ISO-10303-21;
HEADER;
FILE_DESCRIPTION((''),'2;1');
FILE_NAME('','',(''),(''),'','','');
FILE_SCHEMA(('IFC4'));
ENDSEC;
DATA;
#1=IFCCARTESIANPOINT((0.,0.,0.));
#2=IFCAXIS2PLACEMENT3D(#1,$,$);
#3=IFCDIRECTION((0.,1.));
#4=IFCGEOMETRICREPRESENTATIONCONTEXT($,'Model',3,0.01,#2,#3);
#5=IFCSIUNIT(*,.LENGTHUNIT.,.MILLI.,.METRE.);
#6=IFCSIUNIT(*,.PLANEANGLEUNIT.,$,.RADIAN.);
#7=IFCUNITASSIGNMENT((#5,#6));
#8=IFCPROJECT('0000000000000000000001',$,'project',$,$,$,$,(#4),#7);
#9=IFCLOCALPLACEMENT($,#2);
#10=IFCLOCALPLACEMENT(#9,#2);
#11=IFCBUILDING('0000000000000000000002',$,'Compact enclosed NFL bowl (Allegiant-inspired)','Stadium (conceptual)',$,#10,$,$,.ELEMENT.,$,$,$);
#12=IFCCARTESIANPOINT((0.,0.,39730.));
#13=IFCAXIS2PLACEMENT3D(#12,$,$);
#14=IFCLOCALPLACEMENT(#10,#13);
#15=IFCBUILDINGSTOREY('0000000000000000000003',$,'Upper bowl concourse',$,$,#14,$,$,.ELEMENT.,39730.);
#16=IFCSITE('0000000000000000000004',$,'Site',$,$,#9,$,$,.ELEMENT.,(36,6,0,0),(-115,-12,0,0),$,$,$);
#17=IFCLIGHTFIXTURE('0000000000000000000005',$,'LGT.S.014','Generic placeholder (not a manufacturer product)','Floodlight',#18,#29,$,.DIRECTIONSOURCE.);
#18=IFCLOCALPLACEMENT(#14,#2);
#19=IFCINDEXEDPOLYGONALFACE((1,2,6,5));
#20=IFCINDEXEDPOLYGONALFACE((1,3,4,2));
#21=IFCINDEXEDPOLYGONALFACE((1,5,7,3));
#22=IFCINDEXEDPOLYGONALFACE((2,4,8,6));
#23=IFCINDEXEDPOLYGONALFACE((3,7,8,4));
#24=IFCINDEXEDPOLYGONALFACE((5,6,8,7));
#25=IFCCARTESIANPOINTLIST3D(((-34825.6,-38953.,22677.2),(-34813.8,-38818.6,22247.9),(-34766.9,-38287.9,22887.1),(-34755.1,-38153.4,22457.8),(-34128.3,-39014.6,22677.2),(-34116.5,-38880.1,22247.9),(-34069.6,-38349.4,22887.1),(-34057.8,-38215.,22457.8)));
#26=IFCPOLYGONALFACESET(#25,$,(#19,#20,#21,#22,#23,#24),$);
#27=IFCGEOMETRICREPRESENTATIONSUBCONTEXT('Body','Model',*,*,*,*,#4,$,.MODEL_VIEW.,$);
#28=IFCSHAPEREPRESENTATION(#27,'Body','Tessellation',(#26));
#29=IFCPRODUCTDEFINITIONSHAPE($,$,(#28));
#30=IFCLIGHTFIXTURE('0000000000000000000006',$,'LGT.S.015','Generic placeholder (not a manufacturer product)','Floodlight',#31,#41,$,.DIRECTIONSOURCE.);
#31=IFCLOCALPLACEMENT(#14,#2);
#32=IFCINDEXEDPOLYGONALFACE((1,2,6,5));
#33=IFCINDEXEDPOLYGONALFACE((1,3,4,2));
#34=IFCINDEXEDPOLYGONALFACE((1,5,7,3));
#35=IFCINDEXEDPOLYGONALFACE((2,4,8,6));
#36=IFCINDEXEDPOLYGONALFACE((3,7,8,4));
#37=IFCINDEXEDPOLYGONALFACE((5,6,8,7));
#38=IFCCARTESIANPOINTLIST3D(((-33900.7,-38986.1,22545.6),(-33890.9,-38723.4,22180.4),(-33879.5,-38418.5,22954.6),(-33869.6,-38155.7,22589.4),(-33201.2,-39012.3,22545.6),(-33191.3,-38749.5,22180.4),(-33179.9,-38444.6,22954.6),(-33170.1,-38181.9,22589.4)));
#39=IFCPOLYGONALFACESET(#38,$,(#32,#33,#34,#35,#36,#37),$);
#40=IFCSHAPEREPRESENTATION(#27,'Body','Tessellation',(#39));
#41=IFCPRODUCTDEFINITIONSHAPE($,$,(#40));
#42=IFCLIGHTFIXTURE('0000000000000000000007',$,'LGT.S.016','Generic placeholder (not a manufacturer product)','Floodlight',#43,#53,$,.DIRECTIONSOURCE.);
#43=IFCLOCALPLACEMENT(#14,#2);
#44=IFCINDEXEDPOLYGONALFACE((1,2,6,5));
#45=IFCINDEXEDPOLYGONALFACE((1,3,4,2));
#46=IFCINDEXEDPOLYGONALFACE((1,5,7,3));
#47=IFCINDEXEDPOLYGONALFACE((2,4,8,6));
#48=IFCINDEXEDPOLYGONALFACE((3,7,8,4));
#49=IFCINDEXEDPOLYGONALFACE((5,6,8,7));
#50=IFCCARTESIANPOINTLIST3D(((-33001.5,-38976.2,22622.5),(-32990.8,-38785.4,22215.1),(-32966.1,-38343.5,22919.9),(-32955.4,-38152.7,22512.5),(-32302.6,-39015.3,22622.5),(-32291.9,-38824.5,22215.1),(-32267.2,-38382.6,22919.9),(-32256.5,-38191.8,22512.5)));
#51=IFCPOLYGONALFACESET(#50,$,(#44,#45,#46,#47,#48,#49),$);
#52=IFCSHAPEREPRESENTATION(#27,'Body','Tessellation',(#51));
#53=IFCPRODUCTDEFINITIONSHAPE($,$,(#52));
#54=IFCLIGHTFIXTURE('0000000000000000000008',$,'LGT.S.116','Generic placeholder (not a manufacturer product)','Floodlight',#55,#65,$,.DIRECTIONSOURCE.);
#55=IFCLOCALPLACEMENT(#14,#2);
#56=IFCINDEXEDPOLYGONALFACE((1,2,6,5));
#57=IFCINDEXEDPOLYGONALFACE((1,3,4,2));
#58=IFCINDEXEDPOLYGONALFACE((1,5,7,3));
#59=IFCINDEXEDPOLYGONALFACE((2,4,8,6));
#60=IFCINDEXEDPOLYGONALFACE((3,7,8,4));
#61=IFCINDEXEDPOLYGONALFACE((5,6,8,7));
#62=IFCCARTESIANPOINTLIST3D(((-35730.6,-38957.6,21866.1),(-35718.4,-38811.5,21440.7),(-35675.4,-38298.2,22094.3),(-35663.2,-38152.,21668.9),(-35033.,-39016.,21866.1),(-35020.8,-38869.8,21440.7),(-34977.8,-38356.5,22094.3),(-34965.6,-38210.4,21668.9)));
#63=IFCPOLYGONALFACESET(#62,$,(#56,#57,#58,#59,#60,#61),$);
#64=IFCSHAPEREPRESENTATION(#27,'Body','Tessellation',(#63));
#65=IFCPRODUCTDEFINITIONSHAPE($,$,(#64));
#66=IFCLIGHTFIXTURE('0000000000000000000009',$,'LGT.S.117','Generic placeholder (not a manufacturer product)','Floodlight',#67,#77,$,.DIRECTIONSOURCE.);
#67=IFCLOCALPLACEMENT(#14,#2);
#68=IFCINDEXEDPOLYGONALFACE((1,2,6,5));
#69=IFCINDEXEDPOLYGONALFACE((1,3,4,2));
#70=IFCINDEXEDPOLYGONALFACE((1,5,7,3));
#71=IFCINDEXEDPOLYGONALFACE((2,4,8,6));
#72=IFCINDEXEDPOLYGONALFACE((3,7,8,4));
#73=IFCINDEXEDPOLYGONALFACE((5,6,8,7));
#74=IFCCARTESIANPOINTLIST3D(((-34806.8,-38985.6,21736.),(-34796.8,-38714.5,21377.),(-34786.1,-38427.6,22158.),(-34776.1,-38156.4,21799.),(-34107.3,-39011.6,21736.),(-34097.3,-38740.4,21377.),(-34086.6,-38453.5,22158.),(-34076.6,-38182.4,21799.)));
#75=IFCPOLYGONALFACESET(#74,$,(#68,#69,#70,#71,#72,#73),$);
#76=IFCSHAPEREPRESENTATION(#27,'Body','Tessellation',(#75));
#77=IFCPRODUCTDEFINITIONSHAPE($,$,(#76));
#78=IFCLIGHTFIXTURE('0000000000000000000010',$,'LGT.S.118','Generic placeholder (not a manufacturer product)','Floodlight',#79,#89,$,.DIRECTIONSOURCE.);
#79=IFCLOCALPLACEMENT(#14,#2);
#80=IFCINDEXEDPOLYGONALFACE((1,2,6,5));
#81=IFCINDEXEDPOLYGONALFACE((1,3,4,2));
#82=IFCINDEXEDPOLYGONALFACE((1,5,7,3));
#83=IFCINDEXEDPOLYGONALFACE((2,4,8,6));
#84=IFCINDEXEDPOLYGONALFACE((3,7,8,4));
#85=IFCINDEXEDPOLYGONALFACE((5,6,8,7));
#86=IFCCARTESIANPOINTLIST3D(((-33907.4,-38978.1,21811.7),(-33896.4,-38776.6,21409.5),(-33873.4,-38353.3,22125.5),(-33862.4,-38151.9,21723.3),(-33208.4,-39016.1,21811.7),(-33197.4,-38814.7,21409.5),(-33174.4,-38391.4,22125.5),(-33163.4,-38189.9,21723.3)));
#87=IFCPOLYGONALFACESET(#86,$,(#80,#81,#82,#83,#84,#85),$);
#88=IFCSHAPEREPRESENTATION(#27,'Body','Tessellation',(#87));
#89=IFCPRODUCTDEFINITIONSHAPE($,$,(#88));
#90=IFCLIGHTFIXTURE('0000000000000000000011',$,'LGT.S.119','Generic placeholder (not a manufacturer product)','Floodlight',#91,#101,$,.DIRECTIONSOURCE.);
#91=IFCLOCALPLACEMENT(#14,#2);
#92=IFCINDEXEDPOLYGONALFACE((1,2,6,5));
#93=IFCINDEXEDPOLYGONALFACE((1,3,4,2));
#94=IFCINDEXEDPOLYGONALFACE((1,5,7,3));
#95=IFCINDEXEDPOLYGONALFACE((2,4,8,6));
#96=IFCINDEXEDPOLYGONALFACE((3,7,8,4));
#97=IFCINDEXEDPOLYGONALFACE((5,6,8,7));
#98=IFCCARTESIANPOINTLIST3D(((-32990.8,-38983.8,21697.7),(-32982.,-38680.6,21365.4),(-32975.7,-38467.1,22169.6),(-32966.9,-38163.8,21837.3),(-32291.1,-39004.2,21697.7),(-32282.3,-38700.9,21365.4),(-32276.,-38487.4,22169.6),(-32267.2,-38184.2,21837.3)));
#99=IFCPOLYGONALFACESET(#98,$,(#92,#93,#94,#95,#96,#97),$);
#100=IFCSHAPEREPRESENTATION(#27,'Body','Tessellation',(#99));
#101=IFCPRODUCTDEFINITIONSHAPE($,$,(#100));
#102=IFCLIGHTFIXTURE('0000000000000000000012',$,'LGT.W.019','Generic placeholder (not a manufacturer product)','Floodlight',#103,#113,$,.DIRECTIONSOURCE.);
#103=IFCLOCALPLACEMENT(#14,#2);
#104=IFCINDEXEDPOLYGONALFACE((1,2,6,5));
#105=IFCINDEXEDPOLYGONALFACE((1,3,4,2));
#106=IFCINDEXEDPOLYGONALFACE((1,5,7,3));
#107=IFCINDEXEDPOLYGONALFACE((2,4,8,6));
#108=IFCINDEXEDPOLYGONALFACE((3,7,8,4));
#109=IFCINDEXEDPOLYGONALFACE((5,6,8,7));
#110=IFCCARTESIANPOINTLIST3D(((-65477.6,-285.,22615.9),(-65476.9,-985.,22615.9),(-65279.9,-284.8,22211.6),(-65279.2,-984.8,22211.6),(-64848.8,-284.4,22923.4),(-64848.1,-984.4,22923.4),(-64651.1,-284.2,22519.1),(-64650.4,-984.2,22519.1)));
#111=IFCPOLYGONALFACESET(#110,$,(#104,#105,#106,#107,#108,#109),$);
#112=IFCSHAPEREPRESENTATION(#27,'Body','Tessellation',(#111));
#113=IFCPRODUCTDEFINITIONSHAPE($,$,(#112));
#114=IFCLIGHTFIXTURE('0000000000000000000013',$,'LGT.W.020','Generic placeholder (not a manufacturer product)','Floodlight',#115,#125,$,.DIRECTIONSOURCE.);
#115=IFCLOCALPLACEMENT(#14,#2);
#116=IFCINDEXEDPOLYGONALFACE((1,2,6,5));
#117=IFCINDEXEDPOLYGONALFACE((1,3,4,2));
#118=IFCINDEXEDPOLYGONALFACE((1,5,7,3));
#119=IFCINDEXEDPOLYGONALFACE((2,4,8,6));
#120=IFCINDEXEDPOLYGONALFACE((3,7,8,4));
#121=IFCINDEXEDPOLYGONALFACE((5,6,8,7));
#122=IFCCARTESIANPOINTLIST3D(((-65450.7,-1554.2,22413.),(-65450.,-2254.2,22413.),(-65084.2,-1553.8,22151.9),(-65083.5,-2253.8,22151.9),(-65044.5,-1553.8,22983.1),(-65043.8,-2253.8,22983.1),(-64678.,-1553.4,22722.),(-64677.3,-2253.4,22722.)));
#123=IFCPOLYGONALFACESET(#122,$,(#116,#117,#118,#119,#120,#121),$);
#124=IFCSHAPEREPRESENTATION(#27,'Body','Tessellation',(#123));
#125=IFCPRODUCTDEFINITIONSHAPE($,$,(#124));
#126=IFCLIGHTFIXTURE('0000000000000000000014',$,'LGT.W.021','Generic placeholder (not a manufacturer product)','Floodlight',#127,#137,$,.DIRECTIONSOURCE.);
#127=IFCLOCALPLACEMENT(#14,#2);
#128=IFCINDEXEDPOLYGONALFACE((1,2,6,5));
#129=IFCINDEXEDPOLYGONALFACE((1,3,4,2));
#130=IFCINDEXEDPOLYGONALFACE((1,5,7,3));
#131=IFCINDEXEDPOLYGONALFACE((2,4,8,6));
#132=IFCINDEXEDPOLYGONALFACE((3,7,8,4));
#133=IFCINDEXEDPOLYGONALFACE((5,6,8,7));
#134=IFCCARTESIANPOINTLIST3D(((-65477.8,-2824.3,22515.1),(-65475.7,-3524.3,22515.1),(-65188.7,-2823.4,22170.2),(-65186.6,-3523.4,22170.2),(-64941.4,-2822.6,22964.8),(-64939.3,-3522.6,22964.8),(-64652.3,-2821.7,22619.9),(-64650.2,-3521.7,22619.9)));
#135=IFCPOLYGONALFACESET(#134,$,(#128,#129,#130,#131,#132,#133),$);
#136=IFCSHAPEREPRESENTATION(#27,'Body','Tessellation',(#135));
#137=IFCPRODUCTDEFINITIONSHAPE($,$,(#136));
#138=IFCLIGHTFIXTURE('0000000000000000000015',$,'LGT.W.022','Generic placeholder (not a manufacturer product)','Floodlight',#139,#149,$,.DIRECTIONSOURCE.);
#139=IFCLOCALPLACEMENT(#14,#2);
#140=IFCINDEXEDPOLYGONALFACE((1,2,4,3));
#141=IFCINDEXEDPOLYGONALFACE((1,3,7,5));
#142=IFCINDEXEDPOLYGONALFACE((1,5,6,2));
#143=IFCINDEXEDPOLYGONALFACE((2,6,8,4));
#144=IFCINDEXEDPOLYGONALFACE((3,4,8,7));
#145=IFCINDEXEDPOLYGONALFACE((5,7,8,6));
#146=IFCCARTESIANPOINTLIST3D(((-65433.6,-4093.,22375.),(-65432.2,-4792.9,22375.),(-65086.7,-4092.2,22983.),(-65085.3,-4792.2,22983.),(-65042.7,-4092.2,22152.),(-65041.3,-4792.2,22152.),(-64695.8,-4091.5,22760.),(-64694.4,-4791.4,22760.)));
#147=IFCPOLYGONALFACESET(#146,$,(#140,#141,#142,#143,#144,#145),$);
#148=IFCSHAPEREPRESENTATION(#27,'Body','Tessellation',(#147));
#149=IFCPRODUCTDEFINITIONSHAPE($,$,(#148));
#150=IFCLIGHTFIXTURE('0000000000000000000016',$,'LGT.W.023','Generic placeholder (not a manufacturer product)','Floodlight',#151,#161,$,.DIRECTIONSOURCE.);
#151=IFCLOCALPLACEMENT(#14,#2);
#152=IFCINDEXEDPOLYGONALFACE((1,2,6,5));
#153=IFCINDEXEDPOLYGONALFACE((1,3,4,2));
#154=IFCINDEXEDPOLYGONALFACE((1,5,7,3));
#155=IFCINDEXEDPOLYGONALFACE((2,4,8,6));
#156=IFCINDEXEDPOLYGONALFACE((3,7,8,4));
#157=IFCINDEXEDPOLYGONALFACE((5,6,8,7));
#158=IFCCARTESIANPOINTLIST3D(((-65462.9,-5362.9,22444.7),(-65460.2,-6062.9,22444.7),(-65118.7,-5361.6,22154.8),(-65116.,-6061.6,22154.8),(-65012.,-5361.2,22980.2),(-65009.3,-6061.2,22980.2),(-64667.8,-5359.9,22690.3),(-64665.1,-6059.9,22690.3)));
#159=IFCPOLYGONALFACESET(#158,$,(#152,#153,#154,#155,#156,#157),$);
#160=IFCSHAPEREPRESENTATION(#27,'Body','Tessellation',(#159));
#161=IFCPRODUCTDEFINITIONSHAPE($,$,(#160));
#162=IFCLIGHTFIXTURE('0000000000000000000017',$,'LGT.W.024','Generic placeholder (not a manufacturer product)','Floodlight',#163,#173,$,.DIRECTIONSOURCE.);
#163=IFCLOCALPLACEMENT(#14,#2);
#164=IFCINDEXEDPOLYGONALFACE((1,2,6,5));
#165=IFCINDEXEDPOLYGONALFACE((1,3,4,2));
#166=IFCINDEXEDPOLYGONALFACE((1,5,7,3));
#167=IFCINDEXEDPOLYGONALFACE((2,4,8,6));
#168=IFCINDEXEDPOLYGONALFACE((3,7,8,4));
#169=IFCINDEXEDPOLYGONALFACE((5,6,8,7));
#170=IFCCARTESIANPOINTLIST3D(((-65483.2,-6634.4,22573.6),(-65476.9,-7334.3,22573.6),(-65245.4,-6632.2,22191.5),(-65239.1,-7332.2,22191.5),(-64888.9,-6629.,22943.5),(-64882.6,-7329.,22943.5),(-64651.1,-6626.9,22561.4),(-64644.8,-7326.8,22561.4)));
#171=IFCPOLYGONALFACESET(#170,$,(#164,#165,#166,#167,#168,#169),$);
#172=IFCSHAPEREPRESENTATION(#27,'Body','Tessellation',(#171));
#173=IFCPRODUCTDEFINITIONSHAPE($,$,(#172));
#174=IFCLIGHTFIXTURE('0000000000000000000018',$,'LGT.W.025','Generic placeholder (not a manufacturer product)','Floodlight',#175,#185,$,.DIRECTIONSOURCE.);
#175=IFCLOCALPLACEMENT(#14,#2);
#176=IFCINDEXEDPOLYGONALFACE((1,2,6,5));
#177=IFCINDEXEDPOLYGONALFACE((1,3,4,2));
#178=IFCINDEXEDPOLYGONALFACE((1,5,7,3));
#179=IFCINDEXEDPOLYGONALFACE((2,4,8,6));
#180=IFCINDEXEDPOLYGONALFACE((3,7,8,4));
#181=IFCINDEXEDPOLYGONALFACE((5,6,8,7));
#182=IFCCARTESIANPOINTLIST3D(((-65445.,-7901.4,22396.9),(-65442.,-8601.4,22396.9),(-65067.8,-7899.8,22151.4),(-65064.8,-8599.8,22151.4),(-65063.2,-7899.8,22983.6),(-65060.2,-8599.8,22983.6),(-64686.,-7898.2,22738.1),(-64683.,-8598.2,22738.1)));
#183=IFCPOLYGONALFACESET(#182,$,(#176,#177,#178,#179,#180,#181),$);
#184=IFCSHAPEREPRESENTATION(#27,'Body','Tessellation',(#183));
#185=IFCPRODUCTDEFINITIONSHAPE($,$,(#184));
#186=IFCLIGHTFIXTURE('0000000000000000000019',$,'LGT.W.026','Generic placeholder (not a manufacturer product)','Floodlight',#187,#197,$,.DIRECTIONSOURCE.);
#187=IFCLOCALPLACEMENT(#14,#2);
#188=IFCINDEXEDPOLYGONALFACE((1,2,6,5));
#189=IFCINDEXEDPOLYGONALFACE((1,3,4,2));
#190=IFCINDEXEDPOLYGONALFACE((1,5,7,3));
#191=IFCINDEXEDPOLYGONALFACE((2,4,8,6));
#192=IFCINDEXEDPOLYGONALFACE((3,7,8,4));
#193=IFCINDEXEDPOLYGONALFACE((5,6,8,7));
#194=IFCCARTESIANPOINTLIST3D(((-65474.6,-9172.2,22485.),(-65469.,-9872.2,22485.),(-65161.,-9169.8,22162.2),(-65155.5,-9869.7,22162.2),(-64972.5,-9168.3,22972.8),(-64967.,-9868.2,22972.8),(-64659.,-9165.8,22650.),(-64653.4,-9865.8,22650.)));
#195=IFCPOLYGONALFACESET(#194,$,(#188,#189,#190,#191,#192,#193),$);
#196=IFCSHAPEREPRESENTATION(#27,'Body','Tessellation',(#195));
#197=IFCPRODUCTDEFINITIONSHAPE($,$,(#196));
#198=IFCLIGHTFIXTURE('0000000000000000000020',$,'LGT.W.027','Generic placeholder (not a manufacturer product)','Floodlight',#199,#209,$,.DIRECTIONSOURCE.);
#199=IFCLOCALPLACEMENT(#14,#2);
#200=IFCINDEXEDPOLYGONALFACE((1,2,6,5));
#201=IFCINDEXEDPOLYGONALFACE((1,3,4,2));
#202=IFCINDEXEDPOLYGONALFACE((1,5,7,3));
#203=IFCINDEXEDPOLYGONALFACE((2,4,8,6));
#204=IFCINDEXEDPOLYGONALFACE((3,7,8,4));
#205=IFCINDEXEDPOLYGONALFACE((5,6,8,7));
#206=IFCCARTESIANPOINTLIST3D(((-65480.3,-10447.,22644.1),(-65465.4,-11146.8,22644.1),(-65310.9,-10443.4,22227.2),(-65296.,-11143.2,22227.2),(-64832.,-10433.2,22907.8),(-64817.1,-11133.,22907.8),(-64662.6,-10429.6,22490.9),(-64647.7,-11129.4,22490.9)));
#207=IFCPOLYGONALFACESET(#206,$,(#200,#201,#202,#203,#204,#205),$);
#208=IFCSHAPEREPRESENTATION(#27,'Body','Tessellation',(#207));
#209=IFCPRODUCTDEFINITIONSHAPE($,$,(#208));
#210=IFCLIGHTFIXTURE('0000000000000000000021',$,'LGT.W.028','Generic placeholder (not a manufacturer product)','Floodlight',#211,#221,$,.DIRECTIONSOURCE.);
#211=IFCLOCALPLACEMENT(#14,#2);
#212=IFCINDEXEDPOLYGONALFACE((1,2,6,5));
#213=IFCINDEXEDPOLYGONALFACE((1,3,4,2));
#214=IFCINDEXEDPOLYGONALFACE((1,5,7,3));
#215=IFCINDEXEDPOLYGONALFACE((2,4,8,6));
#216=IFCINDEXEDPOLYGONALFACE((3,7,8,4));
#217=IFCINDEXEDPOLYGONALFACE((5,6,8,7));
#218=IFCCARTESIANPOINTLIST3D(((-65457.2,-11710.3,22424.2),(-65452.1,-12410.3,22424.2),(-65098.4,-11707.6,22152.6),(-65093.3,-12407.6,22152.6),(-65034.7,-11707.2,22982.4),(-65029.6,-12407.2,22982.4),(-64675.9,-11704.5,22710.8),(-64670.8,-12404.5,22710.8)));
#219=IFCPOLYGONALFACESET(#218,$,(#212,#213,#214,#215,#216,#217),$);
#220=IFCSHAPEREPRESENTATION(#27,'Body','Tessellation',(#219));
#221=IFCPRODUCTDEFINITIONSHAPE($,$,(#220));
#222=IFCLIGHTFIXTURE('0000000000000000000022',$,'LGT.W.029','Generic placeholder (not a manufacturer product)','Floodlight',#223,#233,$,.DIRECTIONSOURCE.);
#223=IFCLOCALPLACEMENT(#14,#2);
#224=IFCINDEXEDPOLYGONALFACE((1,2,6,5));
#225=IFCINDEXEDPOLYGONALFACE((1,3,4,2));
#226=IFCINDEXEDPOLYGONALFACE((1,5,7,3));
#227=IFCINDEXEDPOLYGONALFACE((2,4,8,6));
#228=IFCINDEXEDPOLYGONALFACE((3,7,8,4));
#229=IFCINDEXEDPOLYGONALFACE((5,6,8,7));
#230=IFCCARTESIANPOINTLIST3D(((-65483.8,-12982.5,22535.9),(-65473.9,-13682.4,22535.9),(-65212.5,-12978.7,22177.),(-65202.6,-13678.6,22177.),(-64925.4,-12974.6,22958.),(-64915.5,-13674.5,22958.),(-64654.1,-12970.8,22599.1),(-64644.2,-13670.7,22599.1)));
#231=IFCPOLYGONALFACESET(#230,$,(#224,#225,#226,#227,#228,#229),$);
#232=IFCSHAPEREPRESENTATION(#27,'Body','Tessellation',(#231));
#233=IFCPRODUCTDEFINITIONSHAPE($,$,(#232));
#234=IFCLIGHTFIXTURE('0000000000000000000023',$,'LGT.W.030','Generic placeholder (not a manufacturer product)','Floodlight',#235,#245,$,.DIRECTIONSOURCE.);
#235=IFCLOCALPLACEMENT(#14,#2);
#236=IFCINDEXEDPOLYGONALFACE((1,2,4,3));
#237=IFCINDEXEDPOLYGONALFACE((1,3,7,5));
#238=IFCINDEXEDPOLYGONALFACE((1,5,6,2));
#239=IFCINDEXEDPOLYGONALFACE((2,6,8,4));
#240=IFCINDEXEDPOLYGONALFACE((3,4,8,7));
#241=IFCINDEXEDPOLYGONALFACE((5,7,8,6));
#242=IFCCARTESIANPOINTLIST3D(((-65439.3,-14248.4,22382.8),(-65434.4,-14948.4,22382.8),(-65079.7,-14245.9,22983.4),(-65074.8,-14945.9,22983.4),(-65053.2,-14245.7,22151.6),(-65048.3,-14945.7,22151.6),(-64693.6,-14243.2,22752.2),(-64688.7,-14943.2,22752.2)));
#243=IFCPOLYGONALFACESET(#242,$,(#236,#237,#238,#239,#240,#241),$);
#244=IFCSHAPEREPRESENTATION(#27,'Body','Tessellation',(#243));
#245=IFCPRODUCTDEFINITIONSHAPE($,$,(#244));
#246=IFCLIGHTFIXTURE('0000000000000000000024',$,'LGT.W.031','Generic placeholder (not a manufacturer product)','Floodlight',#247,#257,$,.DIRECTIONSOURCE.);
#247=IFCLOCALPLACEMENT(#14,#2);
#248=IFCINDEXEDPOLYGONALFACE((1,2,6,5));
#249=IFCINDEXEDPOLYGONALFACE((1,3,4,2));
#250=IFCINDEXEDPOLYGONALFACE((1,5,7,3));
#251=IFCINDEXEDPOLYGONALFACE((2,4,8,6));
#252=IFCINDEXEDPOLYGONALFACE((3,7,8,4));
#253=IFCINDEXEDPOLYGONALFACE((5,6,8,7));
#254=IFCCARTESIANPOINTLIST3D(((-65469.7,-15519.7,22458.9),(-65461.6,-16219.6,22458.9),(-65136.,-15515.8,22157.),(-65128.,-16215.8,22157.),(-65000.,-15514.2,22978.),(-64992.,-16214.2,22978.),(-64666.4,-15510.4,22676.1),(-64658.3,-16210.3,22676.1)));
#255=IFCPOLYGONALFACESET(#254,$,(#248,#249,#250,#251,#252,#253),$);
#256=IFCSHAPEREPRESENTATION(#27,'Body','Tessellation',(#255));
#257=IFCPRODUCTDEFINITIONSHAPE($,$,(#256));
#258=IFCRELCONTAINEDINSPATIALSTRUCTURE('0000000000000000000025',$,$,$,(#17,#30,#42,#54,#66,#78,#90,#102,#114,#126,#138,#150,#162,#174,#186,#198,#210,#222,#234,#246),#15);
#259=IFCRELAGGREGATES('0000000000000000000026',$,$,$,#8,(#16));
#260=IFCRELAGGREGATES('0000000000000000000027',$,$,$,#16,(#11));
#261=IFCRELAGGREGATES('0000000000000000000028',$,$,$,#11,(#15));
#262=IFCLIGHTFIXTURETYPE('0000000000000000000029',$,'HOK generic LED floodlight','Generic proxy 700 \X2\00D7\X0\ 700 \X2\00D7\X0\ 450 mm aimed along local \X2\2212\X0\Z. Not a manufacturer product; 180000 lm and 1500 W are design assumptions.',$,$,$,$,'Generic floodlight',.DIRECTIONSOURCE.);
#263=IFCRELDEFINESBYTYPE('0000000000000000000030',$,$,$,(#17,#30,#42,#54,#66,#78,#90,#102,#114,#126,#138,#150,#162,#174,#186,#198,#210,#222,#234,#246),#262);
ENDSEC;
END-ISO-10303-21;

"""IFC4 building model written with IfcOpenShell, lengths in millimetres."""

from ifc_helpers import new_model, si_unit, direction, frame, origin, place, context, subcontext, project, spatial, rectangle, extrude, source, transform, mapped, type_object, type_shapes, element, save


model = new_model("IFC4")

# Units and contexts
model_context = context("Model", 3, precision=0.01, world=origin(), true_north=direction((0.0, 1.0)))
body_context = subcontext(model_context, "Body", "Model", "MODEL_VIEW")
ifc_project = project(units=[si_unit("LENGTHUNIT", "METRE", prefix="MILLI"), si_unit("PLANEANGLEUNIT", "RADIAN")], contexts=[model_context])

# Site, building, storey
site_placement = place(None, origin())
site = spatial("IfcSite", under=ifc_project, at=site_placement, Name="Site", CompositionType="ELEMENT", RefLatitude=(36, 6, 0, 0), RefLongitude=(-115, -12, 0, 0))
building_placement = place(site_placement, origin())
building = spatial("IfcBuilding", under=site, at=building_placement, Name="Compact enclosed NFL bowl (Allegiant-inspired)", Description="Stadium (conceptual)", CompositionType="ELEMENT")
storey_placement = place(building_placement, frame((0.0, 0.0, 39730.0)))
storey = spatial("IfcBuildingStorey", under=building, at=storey_placement, Name="Upper bowl concourse", CompositionType="ELEMENT", Elevation=39730.0)

# Light fixtures
light_fixture_type = type_object("IfcLightFixtureType", Name="HOK generic LED floodlight", Description="Generic proxy 700 × 700 × 450 mm aimed along local −Z. Not a manufacturer product; 180000 lm and 1500 W are design assumptions.", ElementType="Generic floodlight", PredefinedType="DIRECTIONSOURCE")
shared_shape = source(origin(), body_context, "Body", "SweptSolid", [
    extrude(rectangle(XDim=700.0, YDim=700.0), frame((0.0, 0.0, -225.0)), (0.0, 0.0, 1.0), 450.0),
])
type_shapes(light_fixture_type, [shared_shape])
for number, where, z_axis, x_axis, name in (
    (1, (-34441.7, -38584.0, 22567.5), (-0.02637, -0.29879, 0.953954), (0.996128, -0.087914, 0.0), "LGT.S.014"),
    (2, (-33535.4, -38584.0, 22567.5), (-0.021842, -0.583959, 0.811489), (0.999301, -0.037377, 0.0), "LGT.S.015"),
    (3, (-32629.0, -38584.0, 22567.5), (-0.023708, -0.424088, 0.905311), (0.998441, -0.055817, 0.0), "LGT.S.016"),
    (4, (-35348.1, -38584.0, 21767.5), (-0.02717, -0.324813, 0.945388), (0.99652, -0.083357, 0.0), "LGT.S.116"),
    (5, (-34441.7, -38584.0, 21767.5), (-0.02234, -0.602536, 0.797779), (0.999313, -0.037051, 0.0), "LGT.S.117"),
    (6, (-33535.4, -38584.0, 21767.5), (-0.024372, -0.447673, 0.893865), (0.998521, -0.054361, 0.0), "LGT.S.118"),
    (7, (-32629.0, -38584.0, 21767.5), (-0.019592, -0.673928, 0.738537), (0.999578, -0.02906, 0.0), "LGT.S.119"),
    (8, (-65064.0, -634.6, 22567.5), (-0.439296, -0.000458, 0.898342), (0.001042, -0.999999, 0.0), "LGT.W.019"),
    (9, (-65064.0, -1903.8, 22567.5), (-0.814402, -0.000887, 0.580301), (0.001089, -0.999999, 0.0), "LGT.W.020"),
    (10, (-65064.0, -3173.0, 22567.5), (-0.642417, -0.001952, 0.766353), (0.003038, -0.999995, 0.0), "LGT.W.021"),
    (11, (-65064.0, -4442.2, 22567.5), (-0.868569, -0.001767, 0.495565), (0.002034, -0.999998, 0.0), "LGT.W.022"),
    (12, (-65064.0, -5711.4, 22567.5), (-0.764921, -0.002953, 0.644117), (0.00386, -0.999993, 0.0), "LGT.W.023"),
    (13, (-65064.0, -6980.6, 22567.5), (-0.528415, -0.004756, 0.848973), (0.009001, -0.999959, 0.0), "LGT.W.024"),
    (14, (-65064.0, -8249.8, 22567.5), (-0.838172, -0.003611, 0.545393), (0.004308, -0.999991, 0.0), "LGT.W.025"),
    (15, (-65064.0, -9519.0, 22567.5), (-0.696871, -0.005479, 0.717175), (0.007862, -0.999969, 0.0), "LGT.W.026"),
    (16, (-65064.0, -10788.2, 22567.5), (-0.376607, -0.008021, 0.926338), (0.021293, -0.999773, 0.0), "LGT.W.027"),
    (17, (-65064.0, -12057.4, 22567.5), (-0.79729, -0.005841, 0.603568), (0.007326, -0.999973, 0.0), "LGT.W.028"),
    (18, (-65064.0, -13326.6, 22567.5), (-0.602949, -0.008533, 0.797734), (0.01415, -0.9999, 0.0), "LGT.W.029"),
    (19, (-65064.0, -14595.8, 22567.5), (-0.857962, -0.006018, 0.513678), (0.007014, -0.999975, 0.0), "LGT.W.030"),
    (20, (-65064.0, -15865.0, 22567.5), (-0.741459, -0.008543, 0.670944), (0.011522, -0.999934, 0.0), "LGT.W.031"),
):
    element("IfcLightFixture", number, at=place(storey_placement, frame(where, z_axis=z_axis, x_axis=x_axis)), inside=storey, type_object=light_fixture_type, Name=name, Description="Generic placeholder (not a manufacturer product)", ObjectType="Floodlight", PredefinedType="DIRECTIONSOURCE", context=body_context, shape_type="MappedRepresentation", body=[
        mapped(shared_shape, transform((0.0, 0.0, 0.0))),
    ])

save(model, "model.ifc")
